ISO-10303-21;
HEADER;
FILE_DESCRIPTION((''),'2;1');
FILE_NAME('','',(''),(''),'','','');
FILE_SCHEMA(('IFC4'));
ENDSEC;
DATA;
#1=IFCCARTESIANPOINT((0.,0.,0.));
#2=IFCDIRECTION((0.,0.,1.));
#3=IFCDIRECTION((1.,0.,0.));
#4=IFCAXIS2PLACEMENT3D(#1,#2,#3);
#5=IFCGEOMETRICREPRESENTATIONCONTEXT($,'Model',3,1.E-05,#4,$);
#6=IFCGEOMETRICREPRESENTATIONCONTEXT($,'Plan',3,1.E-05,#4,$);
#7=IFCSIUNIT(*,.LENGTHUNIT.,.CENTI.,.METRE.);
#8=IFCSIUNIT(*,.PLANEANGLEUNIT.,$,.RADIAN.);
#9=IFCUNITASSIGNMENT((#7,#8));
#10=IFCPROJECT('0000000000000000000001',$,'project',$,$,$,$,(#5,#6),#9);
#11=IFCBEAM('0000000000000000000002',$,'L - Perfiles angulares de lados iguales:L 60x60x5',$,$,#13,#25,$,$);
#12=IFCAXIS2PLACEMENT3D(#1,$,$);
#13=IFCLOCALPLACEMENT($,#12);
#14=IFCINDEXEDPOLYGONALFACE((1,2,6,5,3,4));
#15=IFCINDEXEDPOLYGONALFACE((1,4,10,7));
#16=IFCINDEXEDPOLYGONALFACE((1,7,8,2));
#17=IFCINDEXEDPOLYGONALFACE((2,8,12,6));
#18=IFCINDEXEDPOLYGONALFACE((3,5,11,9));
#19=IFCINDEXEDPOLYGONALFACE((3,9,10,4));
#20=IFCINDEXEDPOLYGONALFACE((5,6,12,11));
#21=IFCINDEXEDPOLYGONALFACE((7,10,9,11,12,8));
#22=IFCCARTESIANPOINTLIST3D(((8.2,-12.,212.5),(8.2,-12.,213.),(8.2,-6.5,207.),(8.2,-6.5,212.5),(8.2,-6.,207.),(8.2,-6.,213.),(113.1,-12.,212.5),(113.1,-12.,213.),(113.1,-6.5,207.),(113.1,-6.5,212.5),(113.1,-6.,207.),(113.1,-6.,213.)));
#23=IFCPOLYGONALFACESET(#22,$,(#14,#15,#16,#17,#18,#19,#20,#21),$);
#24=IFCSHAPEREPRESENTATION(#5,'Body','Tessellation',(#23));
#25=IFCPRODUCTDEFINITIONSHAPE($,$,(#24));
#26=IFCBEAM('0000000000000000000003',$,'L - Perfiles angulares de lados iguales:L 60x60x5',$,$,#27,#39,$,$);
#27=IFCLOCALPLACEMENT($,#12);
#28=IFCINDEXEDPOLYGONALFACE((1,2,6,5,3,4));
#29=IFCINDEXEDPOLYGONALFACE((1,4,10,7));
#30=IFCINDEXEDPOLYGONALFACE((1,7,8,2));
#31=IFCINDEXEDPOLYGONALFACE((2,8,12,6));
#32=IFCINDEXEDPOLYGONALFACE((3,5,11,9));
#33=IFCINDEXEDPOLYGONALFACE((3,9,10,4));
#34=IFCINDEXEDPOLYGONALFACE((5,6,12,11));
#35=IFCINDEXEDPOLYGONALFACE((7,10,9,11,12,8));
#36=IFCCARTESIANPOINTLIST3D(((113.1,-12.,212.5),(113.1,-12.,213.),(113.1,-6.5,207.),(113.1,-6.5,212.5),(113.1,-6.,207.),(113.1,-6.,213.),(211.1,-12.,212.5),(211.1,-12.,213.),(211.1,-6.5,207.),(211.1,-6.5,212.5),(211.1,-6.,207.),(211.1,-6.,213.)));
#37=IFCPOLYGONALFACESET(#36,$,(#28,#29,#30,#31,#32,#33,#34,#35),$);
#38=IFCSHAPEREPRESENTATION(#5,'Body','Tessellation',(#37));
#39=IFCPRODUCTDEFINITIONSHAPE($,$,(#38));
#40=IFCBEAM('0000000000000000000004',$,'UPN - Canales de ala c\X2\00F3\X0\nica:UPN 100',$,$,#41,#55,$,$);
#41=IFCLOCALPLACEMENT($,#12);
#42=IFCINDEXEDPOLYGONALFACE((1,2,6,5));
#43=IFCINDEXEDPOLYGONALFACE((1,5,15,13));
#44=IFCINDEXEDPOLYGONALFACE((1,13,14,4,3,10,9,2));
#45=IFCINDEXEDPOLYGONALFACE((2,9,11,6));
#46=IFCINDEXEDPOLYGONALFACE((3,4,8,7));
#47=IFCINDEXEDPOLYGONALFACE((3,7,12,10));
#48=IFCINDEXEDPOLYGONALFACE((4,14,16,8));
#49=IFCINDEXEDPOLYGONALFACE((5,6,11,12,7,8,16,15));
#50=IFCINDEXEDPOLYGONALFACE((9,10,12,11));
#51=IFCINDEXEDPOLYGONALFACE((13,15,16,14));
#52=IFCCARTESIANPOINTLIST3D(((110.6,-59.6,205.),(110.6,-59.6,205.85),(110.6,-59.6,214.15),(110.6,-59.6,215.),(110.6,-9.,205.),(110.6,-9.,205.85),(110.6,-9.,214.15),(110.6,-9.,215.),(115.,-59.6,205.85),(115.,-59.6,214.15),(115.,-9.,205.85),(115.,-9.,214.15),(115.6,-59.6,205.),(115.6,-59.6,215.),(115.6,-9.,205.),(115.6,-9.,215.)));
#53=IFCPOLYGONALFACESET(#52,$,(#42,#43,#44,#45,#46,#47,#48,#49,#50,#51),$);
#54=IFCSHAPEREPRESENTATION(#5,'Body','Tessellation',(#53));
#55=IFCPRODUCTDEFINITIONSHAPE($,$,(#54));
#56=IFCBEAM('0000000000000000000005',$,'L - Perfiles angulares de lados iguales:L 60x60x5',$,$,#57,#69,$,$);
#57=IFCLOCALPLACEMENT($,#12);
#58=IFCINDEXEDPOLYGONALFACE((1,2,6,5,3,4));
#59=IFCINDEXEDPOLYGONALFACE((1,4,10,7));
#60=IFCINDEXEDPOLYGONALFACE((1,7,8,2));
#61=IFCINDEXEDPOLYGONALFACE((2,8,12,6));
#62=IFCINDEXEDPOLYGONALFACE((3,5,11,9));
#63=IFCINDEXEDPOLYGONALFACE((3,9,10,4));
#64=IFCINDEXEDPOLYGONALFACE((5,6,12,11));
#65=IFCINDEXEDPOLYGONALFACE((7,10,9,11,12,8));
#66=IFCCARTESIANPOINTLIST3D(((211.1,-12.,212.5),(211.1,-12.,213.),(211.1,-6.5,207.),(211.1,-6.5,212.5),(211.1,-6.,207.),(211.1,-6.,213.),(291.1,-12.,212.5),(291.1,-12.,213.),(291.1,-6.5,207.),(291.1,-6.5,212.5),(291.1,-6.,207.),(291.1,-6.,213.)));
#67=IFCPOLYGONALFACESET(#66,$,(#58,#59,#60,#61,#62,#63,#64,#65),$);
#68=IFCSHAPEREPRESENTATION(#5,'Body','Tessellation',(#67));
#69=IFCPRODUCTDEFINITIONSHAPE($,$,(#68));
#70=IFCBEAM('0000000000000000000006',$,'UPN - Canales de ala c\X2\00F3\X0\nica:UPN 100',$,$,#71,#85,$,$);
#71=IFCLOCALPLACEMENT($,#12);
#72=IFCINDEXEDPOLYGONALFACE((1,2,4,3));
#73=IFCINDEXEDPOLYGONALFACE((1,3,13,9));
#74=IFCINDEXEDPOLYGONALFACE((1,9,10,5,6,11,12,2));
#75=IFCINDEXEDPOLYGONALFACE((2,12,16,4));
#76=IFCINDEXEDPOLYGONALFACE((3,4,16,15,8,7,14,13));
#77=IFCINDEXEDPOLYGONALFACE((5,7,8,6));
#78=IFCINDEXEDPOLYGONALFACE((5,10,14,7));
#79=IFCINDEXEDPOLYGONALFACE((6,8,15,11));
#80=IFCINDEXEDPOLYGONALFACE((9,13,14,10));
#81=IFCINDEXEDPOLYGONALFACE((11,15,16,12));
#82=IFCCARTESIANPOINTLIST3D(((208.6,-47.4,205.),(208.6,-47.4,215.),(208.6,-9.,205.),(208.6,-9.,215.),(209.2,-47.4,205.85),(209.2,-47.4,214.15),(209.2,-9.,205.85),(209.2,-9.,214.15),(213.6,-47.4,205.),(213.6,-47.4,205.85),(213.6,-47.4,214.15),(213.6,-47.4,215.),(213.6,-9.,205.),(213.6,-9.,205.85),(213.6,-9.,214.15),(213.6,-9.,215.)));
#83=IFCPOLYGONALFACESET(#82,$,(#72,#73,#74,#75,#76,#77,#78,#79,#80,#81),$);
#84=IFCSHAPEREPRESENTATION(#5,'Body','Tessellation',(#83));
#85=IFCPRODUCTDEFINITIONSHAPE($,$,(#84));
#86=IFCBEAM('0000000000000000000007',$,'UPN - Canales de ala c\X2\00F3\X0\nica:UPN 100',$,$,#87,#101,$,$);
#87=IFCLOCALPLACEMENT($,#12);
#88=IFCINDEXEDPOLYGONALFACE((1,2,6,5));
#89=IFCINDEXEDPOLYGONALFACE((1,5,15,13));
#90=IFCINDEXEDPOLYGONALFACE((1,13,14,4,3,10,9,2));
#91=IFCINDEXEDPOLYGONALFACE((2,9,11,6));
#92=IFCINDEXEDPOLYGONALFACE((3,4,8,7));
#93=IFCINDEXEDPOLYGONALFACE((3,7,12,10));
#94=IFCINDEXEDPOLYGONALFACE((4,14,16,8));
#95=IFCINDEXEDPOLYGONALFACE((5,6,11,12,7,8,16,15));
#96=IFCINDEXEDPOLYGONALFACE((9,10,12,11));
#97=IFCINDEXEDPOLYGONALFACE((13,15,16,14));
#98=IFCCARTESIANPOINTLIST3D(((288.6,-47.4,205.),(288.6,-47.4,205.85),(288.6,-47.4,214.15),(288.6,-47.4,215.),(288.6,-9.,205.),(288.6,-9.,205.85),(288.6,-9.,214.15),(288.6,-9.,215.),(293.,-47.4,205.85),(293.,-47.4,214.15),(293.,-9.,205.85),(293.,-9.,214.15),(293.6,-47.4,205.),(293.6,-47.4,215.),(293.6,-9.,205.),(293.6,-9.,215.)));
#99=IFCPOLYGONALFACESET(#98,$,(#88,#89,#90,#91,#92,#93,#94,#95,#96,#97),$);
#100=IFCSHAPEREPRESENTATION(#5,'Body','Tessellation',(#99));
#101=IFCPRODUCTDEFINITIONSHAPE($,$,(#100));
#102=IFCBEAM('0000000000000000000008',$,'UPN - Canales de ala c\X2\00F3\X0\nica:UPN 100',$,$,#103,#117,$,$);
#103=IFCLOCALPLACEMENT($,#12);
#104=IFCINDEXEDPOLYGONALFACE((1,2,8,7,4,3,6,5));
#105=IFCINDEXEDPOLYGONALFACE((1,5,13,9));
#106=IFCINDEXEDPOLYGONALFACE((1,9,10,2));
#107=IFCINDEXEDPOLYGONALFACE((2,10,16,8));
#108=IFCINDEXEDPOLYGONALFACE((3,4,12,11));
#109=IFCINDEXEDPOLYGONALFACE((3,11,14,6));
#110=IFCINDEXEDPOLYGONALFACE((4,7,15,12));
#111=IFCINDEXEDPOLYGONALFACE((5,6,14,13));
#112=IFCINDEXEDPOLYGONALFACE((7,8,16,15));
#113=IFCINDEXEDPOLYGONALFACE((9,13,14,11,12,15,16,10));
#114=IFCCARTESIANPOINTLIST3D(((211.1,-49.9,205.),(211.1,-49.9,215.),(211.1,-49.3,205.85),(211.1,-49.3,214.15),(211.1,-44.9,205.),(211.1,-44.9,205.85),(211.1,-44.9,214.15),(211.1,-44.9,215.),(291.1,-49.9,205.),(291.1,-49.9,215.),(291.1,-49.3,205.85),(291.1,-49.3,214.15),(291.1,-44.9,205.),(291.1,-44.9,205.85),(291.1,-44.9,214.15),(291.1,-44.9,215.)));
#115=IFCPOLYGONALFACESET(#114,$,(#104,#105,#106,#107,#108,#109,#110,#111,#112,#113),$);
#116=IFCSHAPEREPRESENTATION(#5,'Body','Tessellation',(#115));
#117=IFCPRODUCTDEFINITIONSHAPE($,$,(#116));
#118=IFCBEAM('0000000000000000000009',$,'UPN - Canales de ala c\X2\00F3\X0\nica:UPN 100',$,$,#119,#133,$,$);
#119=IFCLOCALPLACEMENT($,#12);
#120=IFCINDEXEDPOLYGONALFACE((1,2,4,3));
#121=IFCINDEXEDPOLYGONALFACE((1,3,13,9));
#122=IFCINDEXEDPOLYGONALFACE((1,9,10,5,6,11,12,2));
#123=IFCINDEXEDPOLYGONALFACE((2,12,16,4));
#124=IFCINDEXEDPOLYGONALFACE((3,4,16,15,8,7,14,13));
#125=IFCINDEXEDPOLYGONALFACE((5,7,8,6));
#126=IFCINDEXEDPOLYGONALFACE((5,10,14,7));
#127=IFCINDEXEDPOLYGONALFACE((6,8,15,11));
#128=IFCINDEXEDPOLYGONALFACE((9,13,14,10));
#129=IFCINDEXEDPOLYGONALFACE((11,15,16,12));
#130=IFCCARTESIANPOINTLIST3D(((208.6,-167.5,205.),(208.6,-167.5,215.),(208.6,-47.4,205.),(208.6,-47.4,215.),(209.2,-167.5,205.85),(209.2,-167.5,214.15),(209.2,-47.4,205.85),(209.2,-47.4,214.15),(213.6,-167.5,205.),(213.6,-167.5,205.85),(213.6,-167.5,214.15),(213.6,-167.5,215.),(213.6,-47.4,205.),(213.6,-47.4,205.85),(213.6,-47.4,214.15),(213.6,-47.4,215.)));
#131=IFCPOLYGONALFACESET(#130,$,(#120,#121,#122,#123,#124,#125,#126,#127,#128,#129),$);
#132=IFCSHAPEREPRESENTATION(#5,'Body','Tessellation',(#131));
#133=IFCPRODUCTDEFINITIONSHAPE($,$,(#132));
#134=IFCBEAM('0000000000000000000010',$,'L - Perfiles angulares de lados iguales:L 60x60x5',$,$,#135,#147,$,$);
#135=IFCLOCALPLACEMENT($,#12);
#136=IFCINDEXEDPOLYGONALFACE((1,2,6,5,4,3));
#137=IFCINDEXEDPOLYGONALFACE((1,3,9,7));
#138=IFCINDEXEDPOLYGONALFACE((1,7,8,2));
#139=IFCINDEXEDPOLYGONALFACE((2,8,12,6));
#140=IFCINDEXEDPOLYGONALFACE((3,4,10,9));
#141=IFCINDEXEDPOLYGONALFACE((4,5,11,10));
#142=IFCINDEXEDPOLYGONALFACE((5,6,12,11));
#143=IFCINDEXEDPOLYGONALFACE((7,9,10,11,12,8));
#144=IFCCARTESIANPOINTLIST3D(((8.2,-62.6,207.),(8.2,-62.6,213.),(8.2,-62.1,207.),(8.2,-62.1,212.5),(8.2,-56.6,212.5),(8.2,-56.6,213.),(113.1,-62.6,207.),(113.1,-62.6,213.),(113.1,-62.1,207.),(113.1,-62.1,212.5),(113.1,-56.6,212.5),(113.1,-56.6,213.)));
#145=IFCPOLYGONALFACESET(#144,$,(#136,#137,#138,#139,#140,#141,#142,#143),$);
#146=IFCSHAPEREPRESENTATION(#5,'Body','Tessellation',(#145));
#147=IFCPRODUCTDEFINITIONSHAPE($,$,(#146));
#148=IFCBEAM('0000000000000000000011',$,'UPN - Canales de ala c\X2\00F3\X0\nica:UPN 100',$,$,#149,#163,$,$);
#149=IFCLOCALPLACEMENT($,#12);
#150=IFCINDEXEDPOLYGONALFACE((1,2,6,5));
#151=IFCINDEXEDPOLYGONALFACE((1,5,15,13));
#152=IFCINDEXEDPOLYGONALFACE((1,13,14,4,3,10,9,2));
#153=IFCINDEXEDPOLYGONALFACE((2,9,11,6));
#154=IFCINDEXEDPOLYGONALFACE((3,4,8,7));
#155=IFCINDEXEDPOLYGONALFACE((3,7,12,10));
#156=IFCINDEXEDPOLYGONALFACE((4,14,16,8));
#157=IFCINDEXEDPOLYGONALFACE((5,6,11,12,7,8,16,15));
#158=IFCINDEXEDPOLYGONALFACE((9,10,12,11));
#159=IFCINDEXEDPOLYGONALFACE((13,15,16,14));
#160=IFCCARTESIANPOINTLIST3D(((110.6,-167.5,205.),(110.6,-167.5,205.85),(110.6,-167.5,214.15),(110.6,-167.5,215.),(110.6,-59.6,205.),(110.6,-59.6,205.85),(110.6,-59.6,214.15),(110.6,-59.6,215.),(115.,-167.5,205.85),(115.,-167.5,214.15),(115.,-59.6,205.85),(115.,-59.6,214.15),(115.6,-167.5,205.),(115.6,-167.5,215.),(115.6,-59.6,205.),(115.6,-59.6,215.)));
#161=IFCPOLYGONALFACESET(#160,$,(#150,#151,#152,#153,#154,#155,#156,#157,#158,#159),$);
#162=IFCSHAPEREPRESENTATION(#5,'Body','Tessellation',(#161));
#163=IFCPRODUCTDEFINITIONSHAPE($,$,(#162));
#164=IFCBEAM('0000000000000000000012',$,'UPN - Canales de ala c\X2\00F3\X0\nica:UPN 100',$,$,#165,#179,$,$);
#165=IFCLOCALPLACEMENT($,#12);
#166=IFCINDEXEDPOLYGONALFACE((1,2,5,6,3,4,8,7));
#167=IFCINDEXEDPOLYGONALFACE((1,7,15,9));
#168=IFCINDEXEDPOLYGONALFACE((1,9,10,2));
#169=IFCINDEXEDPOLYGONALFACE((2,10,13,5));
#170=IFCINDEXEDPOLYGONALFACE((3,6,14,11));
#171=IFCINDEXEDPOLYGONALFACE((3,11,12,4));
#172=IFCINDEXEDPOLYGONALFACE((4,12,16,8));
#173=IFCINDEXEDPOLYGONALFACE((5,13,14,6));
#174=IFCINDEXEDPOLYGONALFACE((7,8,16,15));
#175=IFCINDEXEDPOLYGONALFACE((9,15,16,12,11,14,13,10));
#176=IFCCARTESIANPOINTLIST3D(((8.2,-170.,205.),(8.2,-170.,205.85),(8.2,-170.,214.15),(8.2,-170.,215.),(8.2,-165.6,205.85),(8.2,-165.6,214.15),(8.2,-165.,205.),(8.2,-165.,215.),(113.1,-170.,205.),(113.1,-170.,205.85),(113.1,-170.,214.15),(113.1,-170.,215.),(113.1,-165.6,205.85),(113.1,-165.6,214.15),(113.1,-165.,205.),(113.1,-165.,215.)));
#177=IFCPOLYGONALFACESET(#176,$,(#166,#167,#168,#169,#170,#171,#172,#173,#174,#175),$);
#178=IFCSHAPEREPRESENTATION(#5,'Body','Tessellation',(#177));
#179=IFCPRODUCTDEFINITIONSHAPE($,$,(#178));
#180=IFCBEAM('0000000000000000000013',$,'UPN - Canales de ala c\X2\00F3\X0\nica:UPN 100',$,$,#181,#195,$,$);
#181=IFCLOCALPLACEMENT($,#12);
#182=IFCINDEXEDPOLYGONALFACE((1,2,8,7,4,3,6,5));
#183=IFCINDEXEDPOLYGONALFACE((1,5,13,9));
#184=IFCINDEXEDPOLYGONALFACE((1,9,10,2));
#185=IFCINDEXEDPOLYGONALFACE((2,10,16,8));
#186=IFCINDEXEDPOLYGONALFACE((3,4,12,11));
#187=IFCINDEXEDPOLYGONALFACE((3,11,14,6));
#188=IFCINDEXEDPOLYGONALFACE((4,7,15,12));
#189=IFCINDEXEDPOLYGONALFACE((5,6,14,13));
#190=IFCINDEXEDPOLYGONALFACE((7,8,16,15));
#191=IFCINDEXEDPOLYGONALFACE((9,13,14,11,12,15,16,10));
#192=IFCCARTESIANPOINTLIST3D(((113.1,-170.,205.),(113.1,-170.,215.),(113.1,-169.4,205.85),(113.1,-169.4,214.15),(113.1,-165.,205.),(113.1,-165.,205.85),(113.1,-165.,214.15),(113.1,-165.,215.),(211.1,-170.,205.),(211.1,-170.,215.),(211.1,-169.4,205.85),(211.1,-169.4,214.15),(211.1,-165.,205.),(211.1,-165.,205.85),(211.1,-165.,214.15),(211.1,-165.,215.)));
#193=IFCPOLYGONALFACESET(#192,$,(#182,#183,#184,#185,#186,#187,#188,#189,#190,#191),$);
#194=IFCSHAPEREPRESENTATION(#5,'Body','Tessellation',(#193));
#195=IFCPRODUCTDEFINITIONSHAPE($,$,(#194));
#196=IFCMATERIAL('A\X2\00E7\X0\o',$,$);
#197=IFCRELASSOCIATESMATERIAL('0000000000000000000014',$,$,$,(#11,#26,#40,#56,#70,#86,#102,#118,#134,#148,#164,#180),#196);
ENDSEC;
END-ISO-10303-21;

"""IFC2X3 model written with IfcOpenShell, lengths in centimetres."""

from ifc_helpers import new_model, si_unit, frame, origin_with_axes, origin_2d_with_axis, place, context, project, polyline, u_section, outline, extrude, material, element, save


model = new_model("IFC2X3")

# Units and contexts
model_context = context("Model", 3, precision=1e-05, world=origin_with_axes())
plan_context = context("Plan", 3, precision=1e-05, world=origin_with_axes())
ifc_project = project(units=[si_unit("LENGTHUNIT", "METRE", prefix="CENTI"), si_unit("PLANEANGLEUNIT", "RADIAN")], contexts=[model_context, plan_context])

# Shared definitions
ifc_material = material(Name="Aço")

# Beams
beam_1_placement = place(None, frame((113.1, -9.0, 210.0), z_axis=(-1.0, 0.0, 0.0), x_axis=(0.0, 0.0, 1.0)))
element("IfcBeam", 1, at=beam_1_placement, material=ifc_material, Name="L - Perfiles angulares de lados iguales:L 60x60x5", context=model_context, shape_type="SweptSolid", body=[
    extrude(outline(polyline([(3.0, -3.0), (3.0, 3.0), (-3.0, 3.0), (-3.0, 2.5), (2.5, 2.5), (2.5, -3.0), (3.0, -3.0)])), origin_with_axes(), (0.0, 0.0, 1.0), 104.9),
])
beam_2_placement = place(None, frame((211.1, -9.0, 210.0), z_axis=(-1.0, 0.0, 0.0), x_axis=(0.0, 0.0, 1.0)))
element("IfcBeam", 2, at=beam_2_placement, material=ifc_material, Name="L - Perfiles angulares de lados iguales:L 60x60x5", context=model_context, shape_type="SweptSolid", body=[
    extrude(outline(polyline([(3.0, -3.0), (3.0, 3.0), (-3.0, 3.0), (-3.0, 2.5), (2.5, 2.5), (2.5, -3.0), (3.0, -3.0)])), origin_with_axes(), (0.0, 0.0, 1.0), 98.0),
])
beam_3_placement = place(None, frame((113.1, -59.6, 210.0), z_axis=(0.0, 1.0, 0.0), x_axis=(-1.0, 0.0, 0.0)))
element("IfcBeam", 3, at=beam_3_placement, material=ifc_material, Name="UPN - Canales de ala cónica:UPN 100", context=model_context, shape_type="SweptSolid", body=[
    extrude(u_section(Depth=10.0, FlangeWidth=5.0, WebThickness=0.6, FlangeThickness=0.85, FilletRadius=0.0, EdgeRadius=0.0, FlangeSlope=0.0, CentreOfGravityInX=0.0, at=origin_2d_with_axis()), origin_with_axes(), (0.0, 0.0, 1.0), 50.6),
])
beam_4_placement = place(None, frame((291.1, -9.0, 210.0), z_axis=(-1.0, 0.0, 0.0), x_axis=(0.0, 0.0, 1.0)))
element("IfcBeam", 4, at=beam_4_placement, material=ifc_material, Name="L - Perfiles angulares de lados iguales:L 60x60x5", context=model_context, shape_type="SweptSolid", body=[
    extrude(outline(polyline([(3.0, -3.0), (3.0, 3.0), (-3.0, 3.0), (-3.0, 2.5), (2.5, 2.5), (2.5, -3.0), (3.0, -3.0)])), origin_with_axes(), (0.0, 0.0, 1.0), 80.0),
])
for number, where, z_axis, x_axis, name in (
    (5, (211.1, -47.4, 210.0), (0.0, 1.0, 0.0), (1.0, 0.0, 0.0), "UPN - Canales de ala cónica:UPN 100"),
    (6, (291.1, -47.4, 210.0), (0.0, 1.0, 0.0), (-1.0, 0.0, 0.0), "UPN - Canales de ala cónica:UPN 100"),
):
    element("IfcBeam", number, at=place(None, frame(where, z_axis=z_axis, x_axis=x_axis)), material=ifc_material, Name=name, context=model_context, shape_type="SweptSolid", body=[
        extrude(u_section(Depth=10.0, FlangeWidth=5.0, WebThickness=0.6, FlangeThickness=0.85, FilletRadius=0.0, EdgeRadius=0.0, FlangeSlope=0.0, CentreOfGravityInX=0.0, at=origin_2d_with_axis()), origin_with_axes(), (0.0, 0.0, 1.0), 38.4),
    ])
beam_5_placement = place(None, frame((291.1, -47.4, 210.0), z_axis=(-1.0, 0.0, 0.0), x_axis=(0.0, 1.0, 0.0)))
element("IfcBeam", 7, at=beam_5_placement, material=ifc_material, Name="UPN - Canales de ala cónica:UPN 100", context=model_context, shape_type="SweptSolid", body=[
    extrude(u_section(Depth=10.0, FlangeWidth=5.0, WebThickness=0.6, FlangeThickness=0.85, FilletRadius=0.0, EdgeRadius=0.0, FlangeSlope=0.0, CentreOfGravityInX=0.0, at=origin_2d_with_axis()), origin_with_axes(), (0.0, 0.0, 1.0), 80.0),
])
beam_6_placement = place(None, frame((211.1, -167.5, 210.0), z_axis=(0.0, 1.0, 0.0), x_axis=(1.0, 0.0, 0.0)))
element("IfcBeam", 8, at=beam_6_placement, material=ifc_material, Name="UPN - Canales de ala cónica:UPN 100", context=model_context, shape_type="SweptSolid", body=[
    extrude(u_section(Depth=10.0, FlangeWidth=5.0, WebThickness=0.6, FlangeThickness=0.85, FilletRadius=0.0, EdgeRadius=0.0, FlangeSlope=0.0, CentreOfGravityInX=0.0, at=origin_2d_with_axis()), origin_with_axes(), (0.0, 0.0, 1.0), 120.1),
])
beam_7_placement = place(None, frame((113.1, -59.6, 210.0), z_axis=(-1.0, 0.0, 0.0), x_axis=(0.0, -1.0, 0.0)))
element("IfcBeam", 9, at=beam_7_placement, material=ifc_material, Name="L - Perfiles angulares de lados iguales:L 60x60x5", context=model_context, shape_type="SweptSolid", body=[
    extrude(outline(polyline([(3.0, -3.0), (3.0, 3.0), (-3.0, 3.0), (-3.0, 2.5), (2.5, 2.5), (2.5, -3.0), (3.0, -3.0)])), origin_with_axes(), (0.0, 0.0, 1.0), 104.9),
])
beam_8_placement = place(None, frame((113.1, -167.5, 210.0), z_axis=(0.0, 1.0, 0.0), x_axis=(-1.0, 0.0, 0.0)))
element("IfcBeam", 10, at=beam_8_placement, material=ifc_material, Name="UPN - Canales de ala cónica:UPN 100", context=model_context, shape_type="SweptSolid", body=[
    extrude(u_section(Depth=10.0, FlangeWidth=5.0, WebThickness=0.6, FlangeThickness=0.85, FilletRadius=0.0, EdgeRadius=0.0, FlangeSlope=0.0, CentreOfGravityInX=0.0, at=origin_2d_with_axis()), origin_with_axes(), (0.0, 0.0, 1.0), 107.9),
])
beam_9_placement = place(None, frame((113.1, -167.5, 210.0), z_axis=(-1.0, 0.0, 0.0), x_axis=(0.0, -1.0, 0.0)))
element("IfcBeam", 11, at=beam_9_placement, material=ifc_material, Name="UPN - Canales de ala cónica:UPN 100", context=model_context, shape_type="SweptSolid", body=[
    extrude(u_section(Depth=10.0, FlangeWidth=5.0, WebThickness=0.6, FlangeThickness=0.85, FilletRadius=0.0, EdgeRadius=0.0, FlangeSlope=0.0, CentreOfGravityInX=0.0, at=origin_2d_with_axis()), origin_with_axes(), (0.0, 0.0, 1.0), 104.9),
])
beam_10_placement = place(None, frame((211.1, -167.5, 210.0), z_axis=(-1.0, 0.0, 0.0), x_axis=(0.0, 1.0, 0.0)))
element("IfcBeam", 12, at=beam_10_placement, material=ifc_material, Name="UPN - Canales de ala cónica:UPN 100", context=model_context, shape_type="SweptSolid", body=[
    extrude(u_section(Depth=10.0, FlangeWidth=5.0, WebThickness=0.6, FlangeThickness=0.85, FilletRadius=0.0, EdgeRadius=0.0, FlangeSlope=0.0, CentreOfGravityInX=0.0, at=origin_2d_with_axis()), origin_with_axes(), (0.0, 0.0, 1.0), 98.0),
])

save(model, "model.ifc")
